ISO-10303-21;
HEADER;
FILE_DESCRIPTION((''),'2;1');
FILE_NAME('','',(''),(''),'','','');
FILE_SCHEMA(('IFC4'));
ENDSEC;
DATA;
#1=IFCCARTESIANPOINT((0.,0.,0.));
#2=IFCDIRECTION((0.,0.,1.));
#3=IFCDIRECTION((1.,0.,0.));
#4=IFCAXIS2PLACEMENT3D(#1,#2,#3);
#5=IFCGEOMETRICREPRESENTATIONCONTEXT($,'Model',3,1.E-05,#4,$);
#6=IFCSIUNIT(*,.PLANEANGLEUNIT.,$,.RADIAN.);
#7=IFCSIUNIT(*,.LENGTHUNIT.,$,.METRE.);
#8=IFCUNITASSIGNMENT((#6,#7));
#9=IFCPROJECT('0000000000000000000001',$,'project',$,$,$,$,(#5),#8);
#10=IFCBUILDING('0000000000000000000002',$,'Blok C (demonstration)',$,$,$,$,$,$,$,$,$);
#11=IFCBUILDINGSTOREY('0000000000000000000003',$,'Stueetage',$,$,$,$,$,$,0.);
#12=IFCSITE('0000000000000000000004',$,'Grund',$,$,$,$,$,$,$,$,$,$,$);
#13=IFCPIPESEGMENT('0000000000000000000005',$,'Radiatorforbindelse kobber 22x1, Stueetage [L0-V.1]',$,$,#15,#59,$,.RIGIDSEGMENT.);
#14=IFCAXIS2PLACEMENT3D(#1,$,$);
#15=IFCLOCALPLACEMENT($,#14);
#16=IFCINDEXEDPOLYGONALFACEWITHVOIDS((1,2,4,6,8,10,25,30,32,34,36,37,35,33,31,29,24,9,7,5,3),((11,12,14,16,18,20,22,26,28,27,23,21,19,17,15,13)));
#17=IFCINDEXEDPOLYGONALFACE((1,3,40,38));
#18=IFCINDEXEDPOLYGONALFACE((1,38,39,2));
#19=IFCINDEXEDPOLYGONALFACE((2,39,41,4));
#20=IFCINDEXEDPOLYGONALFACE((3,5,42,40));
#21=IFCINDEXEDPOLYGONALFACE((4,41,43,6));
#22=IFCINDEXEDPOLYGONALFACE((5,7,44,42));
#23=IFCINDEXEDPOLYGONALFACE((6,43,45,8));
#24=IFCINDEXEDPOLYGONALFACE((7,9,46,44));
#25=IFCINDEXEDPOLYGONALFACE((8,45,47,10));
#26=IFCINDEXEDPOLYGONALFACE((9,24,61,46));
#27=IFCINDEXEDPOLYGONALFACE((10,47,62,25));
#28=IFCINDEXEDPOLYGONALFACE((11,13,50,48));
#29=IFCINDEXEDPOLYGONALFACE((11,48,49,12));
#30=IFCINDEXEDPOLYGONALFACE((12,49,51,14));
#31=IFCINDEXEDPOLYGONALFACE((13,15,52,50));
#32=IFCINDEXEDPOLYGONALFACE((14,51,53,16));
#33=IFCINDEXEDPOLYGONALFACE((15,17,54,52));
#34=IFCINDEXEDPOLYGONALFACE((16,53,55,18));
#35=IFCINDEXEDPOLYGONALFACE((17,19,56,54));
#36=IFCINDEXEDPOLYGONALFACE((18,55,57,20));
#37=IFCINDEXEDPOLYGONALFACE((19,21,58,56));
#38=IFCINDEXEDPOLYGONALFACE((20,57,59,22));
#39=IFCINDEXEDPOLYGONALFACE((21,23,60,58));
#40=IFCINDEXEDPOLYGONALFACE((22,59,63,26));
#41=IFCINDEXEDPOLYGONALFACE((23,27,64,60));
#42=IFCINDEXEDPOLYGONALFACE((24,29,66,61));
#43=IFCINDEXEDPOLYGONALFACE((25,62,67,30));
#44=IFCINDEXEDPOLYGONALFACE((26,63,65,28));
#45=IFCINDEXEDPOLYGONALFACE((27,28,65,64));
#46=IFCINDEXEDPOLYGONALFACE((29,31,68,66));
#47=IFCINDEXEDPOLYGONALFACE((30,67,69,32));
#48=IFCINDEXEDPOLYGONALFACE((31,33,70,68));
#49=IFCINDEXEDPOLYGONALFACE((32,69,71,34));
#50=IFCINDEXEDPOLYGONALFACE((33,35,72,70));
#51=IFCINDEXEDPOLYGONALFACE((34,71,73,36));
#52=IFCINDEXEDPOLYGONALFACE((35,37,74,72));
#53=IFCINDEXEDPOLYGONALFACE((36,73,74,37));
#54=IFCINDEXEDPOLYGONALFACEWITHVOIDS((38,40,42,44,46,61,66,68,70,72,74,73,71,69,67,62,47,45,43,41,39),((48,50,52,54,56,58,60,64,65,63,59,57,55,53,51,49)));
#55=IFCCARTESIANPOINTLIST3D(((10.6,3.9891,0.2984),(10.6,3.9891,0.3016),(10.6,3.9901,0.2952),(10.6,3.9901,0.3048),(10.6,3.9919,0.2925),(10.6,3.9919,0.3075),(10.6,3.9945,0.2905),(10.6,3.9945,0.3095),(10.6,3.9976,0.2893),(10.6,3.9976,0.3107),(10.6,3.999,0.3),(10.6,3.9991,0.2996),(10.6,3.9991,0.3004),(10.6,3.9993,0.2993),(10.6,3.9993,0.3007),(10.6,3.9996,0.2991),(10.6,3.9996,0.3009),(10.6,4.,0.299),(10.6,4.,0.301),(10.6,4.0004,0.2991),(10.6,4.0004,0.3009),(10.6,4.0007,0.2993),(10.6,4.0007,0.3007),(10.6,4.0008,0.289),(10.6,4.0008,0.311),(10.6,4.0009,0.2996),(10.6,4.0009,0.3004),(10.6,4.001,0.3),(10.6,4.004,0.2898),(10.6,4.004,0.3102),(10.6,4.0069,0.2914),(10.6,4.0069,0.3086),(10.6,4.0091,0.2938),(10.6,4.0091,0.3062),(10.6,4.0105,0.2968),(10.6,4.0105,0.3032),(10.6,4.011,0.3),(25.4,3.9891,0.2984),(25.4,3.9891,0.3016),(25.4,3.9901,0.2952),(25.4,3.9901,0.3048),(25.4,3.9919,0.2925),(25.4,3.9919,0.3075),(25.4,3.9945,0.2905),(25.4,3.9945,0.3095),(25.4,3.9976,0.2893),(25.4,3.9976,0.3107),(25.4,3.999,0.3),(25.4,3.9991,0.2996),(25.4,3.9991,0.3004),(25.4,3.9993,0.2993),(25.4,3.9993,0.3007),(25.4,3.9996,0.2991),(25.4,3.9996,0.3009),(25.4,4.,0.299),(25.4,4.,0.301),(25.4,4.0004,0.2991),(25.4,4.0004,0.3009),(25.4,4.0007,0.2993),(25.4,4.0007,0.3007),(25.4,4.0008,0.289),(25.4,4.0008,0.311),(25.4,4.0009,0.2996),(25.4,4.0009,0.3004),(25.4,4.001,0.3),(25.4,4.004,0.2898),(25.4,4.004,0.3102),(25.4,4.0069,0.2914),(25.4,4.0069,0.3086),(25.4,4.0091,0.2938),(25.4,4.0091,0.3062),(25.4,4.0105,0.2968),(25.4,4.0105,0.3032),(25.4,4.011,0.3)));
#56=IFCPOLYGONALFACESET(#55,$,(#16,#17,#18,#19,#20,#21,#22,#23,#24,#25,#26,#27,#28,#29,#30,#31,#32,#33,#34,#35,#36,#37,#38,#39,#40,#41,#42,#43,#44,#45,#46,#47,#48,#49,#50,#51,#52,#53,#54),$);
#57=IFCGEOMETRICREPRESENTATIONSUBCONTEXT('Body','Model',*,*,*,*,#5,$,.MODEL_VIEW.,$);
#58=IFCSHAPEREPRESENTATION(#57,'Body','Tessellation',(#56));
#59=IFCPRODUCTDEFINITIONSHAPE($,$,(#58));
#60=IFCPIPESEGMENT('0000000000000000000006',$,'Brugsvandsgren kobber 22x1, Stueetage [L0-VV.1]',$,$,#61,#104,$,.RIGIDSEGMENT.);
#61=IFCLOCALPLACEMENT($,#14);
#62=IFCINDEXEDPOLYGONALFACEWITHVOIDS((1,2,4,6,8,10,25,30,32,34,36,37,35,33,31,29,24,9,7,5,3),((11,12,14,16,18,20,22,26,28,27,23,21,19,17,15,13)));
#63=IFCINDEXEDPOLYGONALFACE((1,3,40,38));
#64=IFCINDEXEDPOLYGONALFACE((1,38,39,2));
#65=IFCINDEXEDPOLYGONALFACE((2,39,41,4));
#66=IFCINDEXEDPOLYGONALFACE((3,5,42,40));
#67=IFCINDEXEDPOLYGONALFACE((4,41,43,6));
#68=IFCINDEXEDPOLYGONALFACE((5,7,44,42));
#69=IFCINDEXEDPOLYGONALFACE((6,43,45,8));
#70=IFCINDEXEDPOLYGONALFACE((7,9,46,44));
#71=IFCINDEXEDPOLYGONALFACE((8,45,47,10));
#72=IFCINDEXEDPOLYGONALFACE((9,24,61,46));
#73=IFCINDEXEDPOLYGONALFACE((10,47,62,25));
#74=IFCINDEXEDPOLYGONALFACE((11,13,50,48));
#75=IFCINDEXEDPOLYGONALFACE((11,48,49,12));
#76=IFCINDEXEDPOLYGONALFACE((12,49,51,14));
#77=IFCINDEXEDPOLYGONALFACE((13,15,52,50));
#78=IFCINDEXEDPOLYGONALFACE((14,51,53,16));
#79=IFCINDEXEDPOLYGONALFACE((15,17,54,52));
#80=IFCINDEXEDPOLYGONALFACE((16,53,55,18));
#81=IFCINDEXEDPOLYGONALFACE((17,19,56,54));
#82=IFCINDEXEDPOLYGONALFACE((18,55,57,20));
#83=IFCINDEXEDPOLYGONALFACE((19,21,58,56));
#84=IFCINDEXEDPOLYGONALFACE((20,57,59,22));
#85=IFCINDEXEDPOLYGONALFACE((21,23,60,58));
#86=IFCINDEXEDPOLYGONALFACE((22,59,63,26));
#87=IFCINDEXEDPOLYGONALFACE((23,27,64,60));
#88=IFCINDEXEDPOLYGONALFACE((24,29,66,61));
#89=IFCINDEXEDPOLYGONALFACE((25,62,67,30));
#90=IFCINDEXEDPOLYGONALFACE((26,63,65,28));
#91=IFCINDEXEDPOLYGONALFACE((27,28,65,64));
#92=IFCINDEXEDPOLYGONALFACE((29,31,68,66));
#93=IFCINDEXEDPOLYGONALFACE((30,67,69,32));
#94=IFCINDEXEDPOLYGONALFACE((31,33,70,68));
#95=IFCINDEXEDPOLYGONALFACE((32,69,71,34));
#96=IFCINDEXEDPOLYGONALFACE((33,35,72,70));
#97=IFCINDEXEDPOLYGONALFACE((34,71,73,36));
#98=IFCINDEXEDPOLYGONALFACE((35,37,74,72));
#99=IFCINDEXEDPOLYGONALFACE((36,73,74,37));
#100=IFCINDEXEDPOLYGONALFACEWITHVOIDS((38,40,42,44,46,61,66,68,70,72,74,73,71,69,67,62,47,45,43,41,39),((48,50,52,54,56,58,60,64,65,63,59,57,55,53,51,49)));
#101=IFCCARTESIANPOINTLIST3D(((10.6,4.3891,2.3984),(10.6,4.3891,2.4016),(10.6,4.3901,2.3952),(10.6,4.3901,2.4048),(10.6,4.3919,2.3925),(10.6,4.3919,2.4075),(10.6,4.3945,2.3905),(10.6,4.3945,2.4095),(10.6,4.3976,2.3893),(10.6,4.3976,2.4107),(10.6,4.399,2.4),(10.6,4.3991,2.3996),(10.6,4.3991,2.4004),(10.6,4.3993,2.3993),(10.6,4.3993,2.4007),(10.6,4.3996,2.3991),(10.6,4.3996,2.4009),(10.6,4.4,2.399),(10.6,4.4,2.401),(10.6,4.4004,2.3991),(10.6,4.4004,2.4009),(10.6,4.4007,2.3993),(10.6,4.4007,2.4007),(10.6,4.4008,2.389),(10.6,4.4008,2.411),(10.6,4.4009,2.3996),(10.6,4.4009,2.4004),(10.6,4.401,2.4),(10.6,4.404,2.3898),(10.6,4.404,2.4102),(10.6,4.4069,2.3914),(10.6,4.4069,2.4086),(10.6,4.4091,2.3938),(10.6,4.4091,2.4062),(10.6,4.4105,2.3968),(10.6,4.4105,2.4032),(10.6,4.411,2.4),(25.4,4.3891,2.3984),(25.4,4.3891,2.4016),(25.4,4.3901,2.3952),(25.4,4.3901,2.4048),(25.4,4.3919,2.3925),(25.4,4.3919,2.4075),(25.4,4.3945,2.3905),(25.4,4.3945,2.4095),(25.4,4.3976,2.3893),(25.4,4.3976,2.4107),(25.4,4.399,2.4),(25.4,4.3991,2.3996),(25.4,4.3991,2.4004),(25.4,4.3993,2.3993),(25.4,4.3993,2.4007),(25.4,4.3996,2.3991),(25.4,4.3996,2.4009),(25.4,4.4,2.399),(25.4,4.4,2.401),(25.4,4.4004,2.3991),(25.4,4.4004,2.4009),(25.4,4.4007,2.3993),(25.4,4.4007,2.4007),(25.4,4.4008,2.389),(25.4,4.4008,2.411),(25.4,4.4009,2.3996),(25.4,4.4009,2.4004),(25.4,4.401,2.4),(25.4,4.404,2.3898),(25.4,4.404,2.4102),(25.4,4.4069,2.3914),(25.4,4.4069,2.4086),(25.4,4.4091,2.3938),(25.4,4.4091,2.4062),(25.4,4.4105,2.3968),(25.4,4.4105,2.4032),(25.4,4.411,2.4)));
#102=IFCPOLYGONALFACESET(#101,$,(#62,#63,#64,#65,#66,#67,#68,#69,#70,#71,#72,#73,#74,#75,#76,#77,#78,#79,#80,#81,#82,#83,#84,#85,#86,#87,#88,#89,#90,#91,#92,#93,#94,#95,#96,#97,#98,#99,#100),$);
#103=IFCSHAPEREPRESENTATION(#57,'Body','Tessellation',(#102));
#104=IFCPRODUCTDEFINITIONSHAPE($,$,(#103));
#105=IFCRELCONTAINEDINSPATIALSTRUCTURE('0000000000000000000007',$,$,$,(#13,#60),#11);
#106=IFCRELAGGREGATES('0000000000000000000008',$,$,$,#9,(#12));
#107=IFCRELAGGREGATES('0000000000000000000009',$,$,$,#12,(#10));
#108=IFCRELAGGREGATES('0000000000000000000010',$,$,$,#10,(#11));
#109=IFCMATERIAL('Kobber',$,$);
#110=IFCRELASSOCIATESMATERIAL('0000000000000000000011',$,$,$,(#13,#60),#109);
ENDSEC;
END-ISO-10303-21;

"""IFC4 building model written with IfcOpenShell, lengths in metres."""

from ifc_helpers import new_model, si_unit, frame, origin_with_axes, place, context, subcontext, project, spatial, hollow_circle, extrude, material, element, save


model = new_model("IFC4")

# Units and contexts
model_context = context("Model", 3, precision=1e-05, world=origin_with_axes())
body_context = subcontext(model_context, "Body", "Model", "MODEL_VIEW")
ifc_project = project(units=[si_unit("PLANEANGLEUNIT", "RADIAN"), si_unit("LENGTHUNIT", "METRE")], contexts=[model_context])

# Site, building, storey
site = spatial("IfcSite", under=ifc_project, Name="Grund")
building = spatial("IfcBuilding", under=site, Name="Blok C (demonstration)")
storey = spatial("IfcBuildingStorey", under=building, Name="Stueetage", Elevation=0.0)

# Pipe segments
ifc_material_1 = material(Name="Kobber")
pipe_segment_1_placement = place(None, origin_with_axes())
element("IfcPipeSegment", 1, at=pipe_segment_1_placement, inside=storey, material=ifc_material_1, Name="Radiatorforbindelse kobber 22x1, Stueetage [L0-V.1]", PredefinedType="RIGIDSEGMENT", context=body_context, shape_type="SweptSolid", body=[
    extrude(hollow_circle(Radius=0.011, WallThickness=0.01), frame((10.6, 4.0, 0.3), z_axis=(1.0, 0.0, 0.0), x_axis=(0.0, 1.0, 0.0)), (0.0, 0.0, 1.0), 14.8),
])
pipe_segment_2_placement = place(None, origin_with_axes())
element("IfcPipeSegment", 2, at=pipe_segment_2_placement, inside=storey, material=ifc_material_1, Name="Brugsvandsgren kobber 22x1, Stueetage [L0-VV.1]", PredefinedType="RIGIDSEGMENT", context=body_context, shape_type="SweptSolid", body=[
    extrude(hollow_circle(Radius=0.011, WallThickness=0.01), frame((10.6, 4.4, 2.4), z_axis=(1.0, 0.0, 0.0), x_axis=(0.0, 1.0, 0.0)), (0.0, 0.0, 1.0), 14.8),
])

save(model, "model.ifc")
